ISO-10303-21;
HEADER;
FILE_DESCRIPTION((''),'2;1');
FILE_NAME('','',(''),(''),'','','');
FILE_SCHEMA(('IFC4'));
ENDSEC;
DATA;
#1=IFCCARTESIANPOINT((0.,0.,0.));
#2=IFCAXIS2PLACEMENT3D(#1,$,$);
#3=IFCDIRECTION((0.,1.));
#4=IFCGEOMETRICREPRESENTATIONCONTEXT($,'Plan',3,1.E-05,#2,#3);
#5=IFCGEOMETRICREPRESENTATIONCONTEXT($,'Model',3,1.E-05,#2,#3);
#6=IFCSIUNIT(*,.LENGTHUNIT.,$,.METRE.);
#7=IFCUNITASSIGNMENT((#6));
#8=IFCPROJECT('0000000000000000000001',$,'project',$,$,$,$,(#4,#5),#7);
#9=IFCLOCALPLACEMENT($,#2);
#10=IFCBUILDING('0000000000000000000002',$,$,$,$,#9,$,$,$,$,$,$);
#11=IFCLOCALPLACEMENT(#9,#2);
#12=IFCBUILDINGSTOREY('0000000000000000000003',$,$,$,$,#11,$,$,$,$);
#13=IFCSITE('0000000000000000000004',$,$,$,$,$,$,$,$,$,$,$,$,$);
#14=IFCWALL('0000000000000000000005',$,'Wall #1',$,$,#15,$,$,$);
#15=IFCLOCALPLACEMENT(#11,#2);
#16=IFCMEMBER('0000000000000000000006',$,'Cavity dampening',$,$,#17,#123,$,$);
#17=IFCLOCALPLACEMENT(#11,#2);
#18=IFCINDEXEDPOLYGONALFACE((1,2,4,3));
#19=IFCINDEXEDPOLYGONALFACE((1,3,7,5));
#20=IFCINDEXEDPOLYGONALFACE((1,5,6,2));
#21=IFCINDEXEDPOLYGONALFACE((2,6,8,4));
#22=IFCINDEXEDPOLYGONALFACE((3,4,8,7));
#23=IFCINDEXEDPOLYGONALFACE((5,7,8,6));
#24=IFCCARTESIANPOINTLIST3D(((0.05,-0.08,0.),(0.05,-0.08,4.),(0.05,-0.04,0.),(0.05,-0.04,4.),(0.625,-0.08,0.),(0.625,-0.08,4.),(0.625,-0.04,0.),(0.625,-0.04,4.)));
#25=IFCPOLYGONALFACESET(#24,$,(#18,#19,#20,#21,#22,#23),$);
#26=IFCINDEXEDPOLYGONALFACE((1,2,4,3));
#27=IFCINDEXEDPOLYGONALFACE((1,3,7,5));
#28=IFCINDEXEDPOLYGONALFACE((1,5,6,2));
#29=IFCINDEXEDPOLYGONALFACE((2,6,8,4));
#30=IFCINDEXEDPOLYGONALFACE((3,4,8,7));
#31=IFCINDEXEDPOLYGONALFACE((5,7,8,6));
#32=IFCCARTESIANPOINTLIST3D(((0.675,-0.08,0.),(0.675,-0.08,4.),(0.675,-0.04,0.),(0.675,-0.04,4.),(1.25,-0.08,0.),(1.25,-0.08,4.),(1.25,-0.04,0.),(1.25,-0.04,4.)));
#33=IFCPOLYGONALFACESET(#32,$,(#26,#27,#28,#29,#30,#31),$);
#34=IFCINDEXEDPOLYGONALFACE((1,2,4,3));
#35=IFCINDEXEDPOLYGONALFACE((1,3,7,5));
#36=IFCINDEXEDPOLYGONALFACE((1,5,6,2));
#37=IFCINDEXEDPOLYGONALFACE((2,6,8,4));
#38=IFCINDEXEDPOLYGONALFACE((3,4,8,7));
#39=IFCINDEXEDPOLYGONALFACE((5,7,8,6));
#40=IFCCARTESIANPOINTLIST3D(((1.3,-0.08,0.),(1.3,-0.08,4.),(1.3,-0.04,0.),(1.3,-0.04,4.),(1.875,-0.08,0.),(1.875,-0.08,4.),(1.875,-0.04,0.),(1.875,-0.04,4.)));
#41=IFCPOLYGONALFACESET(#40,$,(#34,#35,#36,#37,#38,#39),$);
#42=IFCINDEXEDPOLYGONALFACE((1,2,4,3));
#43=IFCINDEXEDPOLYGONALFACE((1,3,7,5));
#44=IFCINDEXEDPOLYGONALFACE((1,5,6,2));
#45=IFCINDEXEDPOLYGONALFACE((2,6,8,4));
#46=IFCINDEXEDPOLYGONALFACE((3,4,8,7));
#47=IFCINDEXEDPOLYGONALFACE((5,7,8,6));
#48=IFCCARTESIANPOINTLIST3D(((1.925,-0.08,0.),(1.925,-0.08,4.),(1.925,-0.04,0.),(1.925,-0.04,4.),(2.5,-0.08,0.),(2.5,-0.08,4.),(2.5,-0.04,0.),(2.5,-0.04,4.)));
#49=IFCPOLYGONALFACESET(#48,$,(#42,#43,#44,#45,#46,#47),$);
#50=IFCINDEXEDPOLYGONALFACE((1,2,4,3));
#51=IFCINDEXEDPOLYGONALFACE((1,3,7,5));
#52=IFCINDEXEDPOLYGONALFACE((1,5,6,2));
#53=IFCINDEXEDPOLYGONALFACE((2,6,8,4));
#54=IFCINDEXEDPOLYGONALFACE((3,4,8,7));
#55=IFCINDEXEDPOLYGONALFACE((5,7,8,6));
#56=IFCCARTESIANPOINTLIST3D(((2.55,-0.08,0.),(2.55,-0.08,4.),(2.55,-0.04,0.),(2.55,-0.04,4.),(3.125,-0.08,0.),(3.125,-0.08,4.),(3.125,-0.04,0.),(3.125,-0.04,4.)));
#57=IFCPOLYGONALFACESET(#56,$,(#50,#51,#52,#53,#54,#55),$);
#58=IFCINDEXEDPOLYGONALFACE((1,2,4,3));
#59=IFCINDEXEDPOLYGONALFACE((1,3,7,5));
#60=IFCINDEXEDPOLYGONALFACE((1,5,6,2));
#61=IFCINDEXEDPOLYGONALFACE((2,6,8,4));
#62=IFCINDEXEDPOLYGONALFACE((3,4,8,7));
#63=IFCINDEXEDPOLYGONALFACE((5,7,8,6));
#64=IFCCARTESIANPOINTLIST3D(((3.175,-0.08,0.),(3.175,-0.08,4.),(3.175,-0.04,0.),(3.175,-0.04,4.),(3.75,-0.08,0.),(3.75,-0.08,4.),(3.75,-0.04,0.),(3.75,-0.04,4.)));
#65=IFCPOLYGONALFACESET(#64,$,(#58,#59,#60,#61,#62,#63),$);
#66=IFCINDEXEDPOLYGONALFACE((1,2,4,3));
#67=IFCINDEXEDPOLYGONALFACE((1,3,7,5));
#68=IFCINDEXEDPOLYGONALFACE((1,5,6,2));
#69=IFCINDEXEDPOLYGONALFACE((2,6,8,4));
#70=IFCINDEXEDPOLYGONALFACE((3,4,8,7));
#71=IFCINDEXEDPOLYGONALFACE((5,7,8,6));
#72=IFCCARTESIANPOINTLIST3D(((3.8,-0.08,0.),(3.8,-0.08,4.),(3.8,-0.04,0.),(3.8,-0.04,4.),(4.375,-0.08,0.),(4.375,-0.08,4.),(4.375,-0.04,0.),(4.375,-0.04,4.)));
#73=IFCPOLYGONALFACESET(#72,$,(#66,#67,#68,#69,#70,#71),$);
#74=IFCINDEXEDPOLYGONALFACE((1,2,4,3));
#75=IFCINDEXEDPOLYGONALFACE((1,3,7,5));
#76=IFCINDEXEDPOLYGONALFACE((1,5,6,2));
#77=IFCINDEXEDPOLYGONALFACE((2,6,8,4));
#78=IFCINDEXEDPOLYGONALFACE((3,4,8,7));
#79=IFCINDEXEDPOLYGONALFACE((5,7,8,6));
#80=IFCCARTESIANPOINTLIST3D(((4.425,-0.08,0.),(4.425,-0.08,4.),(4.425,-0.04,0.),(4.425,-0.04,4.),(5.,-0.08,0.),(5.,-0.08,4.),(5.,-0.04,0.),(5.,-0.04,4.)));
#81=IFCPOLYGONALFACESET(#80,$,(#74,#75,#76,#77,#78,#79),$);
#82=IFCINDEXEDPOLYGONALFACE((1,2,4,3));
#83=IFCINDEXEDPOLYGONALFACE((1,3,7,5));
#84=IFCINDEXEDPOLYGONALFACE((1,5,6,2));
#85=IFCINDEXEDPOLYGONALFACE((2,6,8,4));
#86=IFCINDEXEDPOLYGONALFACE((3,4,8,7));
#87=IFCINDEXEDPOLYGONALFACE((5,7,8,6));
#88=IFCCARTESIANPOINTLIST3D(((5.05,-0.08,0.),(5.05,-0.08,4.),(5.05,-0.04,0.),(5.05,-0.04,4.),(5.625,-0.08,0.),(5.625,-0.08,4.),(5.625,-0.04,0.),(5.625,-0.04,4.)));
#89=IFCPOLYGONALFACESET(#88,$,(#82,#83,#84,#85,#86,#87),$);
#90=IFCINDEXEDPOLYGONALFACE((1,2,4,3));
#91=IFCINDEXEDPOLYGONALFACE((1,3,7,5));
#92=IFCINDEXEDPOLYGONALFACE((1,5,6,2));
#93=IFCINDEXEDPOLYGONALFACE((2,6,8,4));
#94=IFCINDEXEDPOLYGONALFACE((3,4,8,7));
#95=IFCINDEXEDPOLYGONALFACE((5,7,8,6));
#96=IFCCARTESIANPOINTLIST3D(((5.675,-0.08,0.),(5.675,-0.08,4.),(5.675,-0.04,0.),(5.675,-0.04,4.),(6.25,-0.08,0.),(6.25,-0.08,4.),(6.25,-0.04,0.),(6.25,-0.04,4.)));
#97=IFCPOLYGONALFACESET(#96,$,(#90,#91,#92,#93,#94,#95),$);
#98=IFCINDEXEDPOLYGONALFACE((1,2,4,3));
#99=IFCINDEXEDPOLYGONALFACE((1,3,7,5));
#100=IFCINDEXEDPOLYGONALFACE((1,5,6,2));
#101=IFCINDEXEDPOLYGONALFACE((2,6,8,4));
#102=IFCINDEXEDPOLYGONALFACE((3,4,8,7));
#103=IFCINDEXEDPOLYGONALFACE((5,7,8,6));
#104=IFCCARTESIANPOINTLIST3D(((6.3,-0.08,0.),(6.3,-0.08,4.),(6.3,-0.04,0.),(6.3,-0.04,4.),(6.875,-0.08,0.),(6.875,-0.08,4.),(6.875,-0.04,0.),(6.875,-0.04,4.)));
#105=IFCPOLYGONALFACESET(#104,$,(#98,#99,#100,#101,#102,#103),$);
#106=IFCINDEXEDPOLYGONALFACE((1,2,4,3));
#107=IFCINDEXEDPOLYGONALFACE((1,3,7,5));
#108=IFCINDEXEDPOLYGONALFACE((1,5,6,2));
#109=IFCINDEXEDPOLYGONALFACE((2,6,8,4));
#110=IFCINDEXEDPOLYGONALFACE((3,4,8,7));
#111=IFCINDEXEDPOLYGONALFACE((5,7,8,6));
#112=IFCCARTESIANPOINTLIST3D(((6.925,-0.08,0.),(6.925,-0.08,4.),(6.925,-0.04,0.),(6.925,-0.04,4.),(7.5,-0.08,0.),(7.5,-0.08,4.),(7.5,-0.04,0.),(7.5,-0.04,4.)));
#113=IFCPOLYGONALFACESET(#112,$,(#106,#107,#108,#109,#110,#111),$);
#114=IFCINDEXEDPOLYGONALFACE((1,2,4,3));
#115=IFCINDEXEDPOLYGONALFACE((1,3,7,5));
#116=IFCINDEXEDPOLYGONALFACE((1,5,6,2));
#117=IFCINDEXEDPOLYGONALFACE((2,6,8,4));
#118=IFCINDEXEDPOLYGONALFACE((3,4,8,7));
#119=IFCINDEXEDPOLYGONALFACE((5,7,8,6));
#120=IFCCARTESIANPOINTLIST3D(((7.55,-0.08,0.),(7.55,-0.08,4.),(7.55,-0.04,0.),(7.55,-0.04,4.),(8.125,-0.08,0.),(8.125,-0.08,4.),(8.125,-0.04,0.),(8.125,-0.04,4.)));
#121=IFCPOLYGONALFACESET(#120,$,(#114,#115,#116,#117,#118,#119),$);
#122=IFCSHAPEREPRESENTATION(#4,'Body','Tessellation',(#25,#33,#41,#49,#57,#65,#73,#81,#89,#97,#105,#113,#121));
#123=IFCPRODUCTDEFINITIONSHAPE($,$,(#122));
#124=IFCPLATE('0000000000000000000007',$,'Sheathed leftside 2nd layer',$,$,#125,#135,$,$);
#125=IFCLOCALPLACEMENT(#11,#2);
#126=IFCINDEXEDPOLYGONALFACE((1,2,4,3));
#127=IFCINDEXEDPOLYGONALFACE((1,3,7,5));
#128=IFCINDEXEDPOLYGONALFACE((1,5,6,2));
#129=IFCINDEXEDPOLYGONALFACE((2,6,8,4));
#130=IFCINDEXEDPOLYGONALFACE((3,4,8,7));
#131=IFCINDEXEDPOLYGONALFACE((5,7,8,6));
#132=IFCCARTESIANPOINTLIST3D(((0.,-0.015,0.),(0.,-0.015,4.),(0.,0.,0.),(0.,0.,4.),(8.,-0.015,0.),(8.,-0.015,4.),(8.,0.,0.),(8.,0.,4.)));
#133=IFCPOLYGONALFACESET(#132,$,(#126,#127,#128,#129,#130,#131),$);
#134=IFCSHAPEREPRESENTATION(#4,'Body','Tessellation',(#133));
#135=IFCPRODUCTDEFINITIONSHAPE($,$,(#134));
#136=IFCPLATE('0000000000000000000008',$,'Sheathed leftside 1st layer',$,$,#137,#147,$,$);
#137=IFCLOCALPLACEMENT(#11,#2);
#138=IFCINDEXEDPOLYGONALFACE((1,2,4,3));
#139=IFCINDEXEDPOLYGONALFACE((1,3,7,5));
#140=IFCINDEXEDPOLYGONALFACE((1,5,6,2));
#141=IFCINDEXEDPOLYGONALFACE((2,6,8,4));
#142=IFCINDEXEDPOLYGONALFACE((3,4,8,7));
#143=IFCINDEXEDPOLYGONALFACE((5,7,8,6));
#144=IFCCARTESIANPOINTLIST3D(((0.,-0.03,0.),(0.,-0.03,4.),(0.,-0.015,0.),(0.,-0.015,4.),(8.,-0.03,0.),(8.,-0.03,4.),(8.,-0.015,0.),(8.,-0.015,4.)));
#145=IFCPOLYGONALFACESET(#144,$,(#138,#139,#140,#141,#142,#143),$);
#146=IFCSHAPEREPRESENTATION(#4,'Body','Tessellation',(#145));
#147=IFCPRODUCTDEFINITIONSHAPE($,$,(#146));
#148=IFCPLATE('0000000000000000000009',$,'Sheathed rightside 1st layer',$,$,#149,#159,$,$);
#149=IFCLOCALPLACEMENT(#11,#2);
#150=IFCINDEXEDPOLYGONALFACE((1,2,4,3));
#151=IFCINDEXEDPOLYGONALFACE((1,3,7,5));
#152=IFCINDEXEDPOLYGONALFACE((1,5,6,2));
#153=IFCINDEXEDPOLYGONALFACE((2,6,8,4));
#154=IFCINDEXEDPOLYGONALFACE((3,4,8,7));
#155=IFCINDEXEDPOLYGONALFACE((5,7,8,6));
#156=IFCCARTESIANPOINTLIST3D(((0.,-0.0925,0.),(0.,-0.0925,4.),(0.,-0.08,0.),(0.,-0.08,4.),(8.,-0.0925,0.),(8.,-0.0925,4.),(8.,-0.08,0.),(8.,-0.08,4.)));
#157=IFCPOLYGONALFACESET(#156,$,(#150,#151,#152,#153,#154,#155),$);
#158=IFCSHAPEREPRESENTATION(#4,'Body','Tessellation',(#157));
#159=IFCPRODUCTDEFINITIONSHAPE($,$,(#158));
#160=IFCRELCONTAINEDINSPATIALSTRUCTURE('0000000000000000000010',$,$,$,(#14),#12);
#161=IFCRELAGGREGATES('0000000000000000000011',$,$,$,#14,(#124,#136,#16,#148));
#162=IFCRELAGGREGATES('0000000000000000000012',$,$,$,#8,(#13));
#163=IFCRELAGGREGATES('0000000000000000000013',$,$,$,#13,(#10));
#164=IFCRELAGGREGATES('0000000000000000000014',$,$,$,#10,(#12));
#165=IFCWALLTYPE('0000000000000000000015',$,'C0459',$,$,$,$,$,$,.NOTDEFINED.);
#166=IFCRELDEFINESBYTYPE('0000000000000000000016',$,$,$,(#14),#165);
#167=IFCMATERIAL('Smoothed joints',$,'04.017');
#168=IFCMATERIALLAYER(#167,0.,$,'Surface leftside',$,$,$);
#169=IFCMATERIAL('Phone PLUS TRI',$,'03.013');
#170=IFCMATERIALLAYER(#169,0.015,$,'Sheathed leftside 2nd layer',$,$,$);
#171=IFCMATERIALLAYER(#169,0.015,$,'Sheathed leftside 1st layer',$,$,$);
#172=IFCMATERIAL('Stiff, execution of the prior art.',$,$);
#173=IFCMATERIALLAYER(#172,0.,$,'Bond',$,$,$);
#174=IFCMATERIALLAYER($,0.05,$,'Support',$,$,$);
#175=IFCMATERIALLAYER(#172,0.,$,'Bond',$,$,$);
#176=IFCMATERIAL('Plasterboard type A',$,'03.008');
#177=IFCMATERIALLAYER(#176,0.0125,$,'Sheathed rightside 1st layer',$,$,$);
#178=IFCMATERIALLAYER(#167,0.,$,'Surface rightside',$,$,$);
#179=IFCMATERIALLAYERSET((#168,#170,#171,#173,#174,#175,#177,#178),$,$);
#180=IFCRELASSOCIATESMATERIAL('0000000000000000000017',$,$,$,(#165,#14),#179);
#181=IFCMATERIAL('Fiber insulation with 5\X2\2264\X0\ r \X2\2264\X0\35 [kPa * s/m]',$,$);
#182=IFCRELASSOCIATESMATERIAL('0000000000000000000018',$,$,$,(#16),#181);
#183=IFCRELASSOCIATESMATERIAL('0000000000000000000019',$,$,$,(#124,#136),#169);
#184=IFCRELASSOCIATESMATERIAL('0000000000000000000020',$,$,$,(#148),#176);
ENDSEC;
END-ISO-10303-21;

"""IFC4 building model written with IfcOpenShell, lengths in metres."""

from ifc_helpers import new_model, si_unit, direction, frame, frame_2d, origin, origin_with_axes, place, context, project, spatial, rectangle, extrude, material, layer, layer_set, type_object, element, aggregate, save


model = new_model("IFC4")

# Units and contexts
plan_context = context("Plan", 3, precision=1e-05, world=origin(), true_north=direction((0.0, 1.0)))
model_context = context("Model", 3, precision=1e-05, world=origin(), true_north=direction((0.0, 1.0)))
ifc_project = project(units=[si_unit("LENGTHUNIT", "METRE")], contexts=[plan_context, model_context])

# Site, building, storey
site = spatial("IfcSite", under=ifc_project)
building_placement = place(None, origin())
building = spatial("IfcBuilding", under=site, at=building_placement)
storey_placement = place(building_placement, origin())
storey = spatial("IfcBuildingStorey", under=building, at=storey_placement)

# Wall, member, plates
ifc_material_1 = material(Name="Smoothed joints", Category="04.017")
ifc_layer_1 = layer(ifc_material_1, 0.0, Name="Surface leftside")
ifc_material_2 = material(Name="Phone PLUS TRI", Category="03.013")
ifc_layer_2 = layer(ifc_material_2, 0.015, Name="Sheathed leftside 2nd layer")
ifc_layer_3 = layer(ifc_material_2, 0.015, Name="Sheathed leftside 1st layer")
ifc_material_3 = material(Name="Stiff, execution of the prior art.")
ifc_layer_4 = layer(ifc_material_3, 0.0, Name="Bond")
ifc_layer_5 = layer(None, 0.05, Name="Support")
ifc_layer_6 = layer(ifc_material_3, 0.0, Name="Bond")
ifc_material_4 = material(Name="Plasterboard type A", Category="03.008")
ifc_layer_7 = layer(ifc_material_4, 0.0125, Name="Sheathed rightside 1st layer")
ifc_layer_8 = layer(ifc_material_1, 0.0, Name="Surface rightside")
ifc_layer_set = layer_set([ifc_layer_1, ifc_layer_2, ifc_layer_3, ifc_layer_4, ifc_layer_5, ifc_layer_6, ifc_layer_7, ifc_layer_8])
wall_type = type_object("IfcWallType", Name="C0459", PredefinedType="NOTDEFINED", material=ifc_layer_set)
wall_placement = place(None, frame((0.0, 0.0, 0.0), z_axis=(0.0, -1.0, 0.0), x_axis=(1.0, 0.0, 0.0)))
wall = element("IfcWall", 1, at=wall_placement, inside=storey, type_object=wall_type, material=ifc_layer_set, Name="Wall #1")
ifc_material_5 = material(Name="Fiber insulation with 5≤ r ≤35 [kPa * s/m]")
member_1_placement = place(wall_placement, origin())
member_1 = element("IfcMember", 2, at=member_1_placement, material=ifc_material_5, Name="Cavity dampening", context=plan_context, shape_type="SweptSolid", body=[
    extrude(rectangle(XDim=0.575, YDim=0.04, at=frame_2d((0.2875, 0.02), x_axis=(1.0, 0.0))), frame((0.05, 4.0, 0.04), z_axis=(0.0, -1.0, 0.0), x_axis=(1.0, 0.0, 0.0)), (0.0, 0.0, 1.0), 4.0),
    extrude(rectangle(XDim=0.575, YDim=0.04, at=frame_2d((0.2875, 0.02), x_axis=(1.0, 0.0))), frame((0.675, 4.0, 0.04), z_axis=(0.0, -1.0, 0.0), x_axis=(1.0, 0.0, 0.0)), (0.0, 0.0, 1.0), 4.0),
    extrude(rectangle(XDim=0.575, YDim=0.04, at=frame_2d((0.2875, 0.02), x_axis=(1.0, 0.0))), frame((1.3, 4.0, 0.04), z_axis=(0.0, -1.0, 0.0), x_axis=(1.0, 0.0, 0.0)), (0.0, 0.0, 1.0), 4.0),
    extrude(rectangle(XDim=0.575, YDim=0.04, at=frame_2d((0.2875, 0.02), x_axis=(1.0, 0.0))), frame((1.925, 4.0, 0.04), z_axis=(0.0, -1.0, 0.0), x_axis=(1.0, 0.0, 0.0)), (0.0, 0.0, 1.0), 4.0),
    extrude(rectangle(XDim=0.575, YDim=0.04, at=frame_2d((0.2875, 0.02), x_axis=(1.0, 0.0))), frame((2.55, 4.0, 0.04), z_axis=(0.0, -1.0, 0.0), x_axis=(1.0, 0.0, 0.0)), (0.0, 0.0, 1.0), 4.0),
    extrude(rectangle(XDim=0.575, YDim=0.04, at=frame_2d((0.2875, 0.02), x_axis=(1.0, 0.0))), frame((3.175, 4.0, 0.04), z_axis=(0.0, -1.0, 0.0), x_axis=(1.0, 0.0, 0.0)), (0.0, 0.0, 1.0), 4.0),
    extrude(rectangle(XDim=0.575, YDim=0.04, at=frame_2d((0.2875, 0.02), x_axis=(1.0, 0.0))), frame((3.8, 4.0, 0.04), z_axis=(0.0, -1.0, 0.0), x_axis=(1.0, 0.0, 0.0)), (0.0, 0.0, 1.0), 4.0),
    extrude(rectangle(XDim=0.575, YDim=0.04, at=frame_2d((0.2875, 0.02), x_axis=(1.0, 0.0))), frame((4.425, 4.0, 0.04), z_axis=(0.0, -1.0, 0.0), x_axis=(1.0, 0.0, 0.0)), (0.0, 0.0, 1.0), 4.0),
    extrude(rectangle(XDim=0.575, YDim=0.04, at=frame_2d((0.2875, 0.02), x_axis=(1.0, 0.0))), frame((5.05, 4.0, 0.04), z_axis=(0.0, -1.0, 0.0), x_axis=(1.0, 0.0, 0.0)), (0.0, 0.0, 1.0), 4.0),
    extrude(rectangle(XDim=0.575, YDim=0.04, at=frame_2d((0.2875, 0.02), x_axis=(1.0, 0.0))), frame((5.675, 4.0, 0.04), z_axis=(0.0, -1.0, 0.0), x_axis=(1.0, 0.0, 0.0)), (0.0, 0.0, 1.0), 4.0),
    extrude(rectangle(XDim=0.575, YDim=0.04, at=frame_2d((0.2875, 0.02), x_axis=(1.0, 0.0))), frame((6.3, 4.0, 0.04), z_axis=(0.0, -1.0, 0.0), x_axis=(1.0, 0.0, 0.0)), (0.0, 0.0, 1.0), 4.0),
    extrude(rectangle(XDim=0.575, YDim=0.04, at=frame_2d((0.2875, 0.02), x_axis=(1.0, 0.0))), frame((6.925, 4.0, 0.04), z_axis=(0.0, -1.0, 0.0), x_axis=(1.0, 0.0, 0.0)), (0.0, 0.0, 1.0), 4.0),
    extrude(rectangle(XDim=0.575, YDim=0.04, at=frame_2d((0.2875, 0.02), x_axis=(1.0, 0.0))), frame((7.55, 4.0, 0.04), z_axis=(0.0, -1.0, 0.0), x_axis=(1.0, 0.0, 0.0)), (0.0, 0.0, 1.0), 4.0),
])
plate_1_placement = place(wall_placement, origin())
plate_1 = element("IfcPlate", 3, at=plate_1_placement, material=ifc_material_2, Name="Sheathed leftside 2nd layer", context=plan_context, shape_type="SweptSolid", body=[
    extrude(rectangle(XDim=8.0, YDim=4.0, at=frame_2d((4.0, 2.0), x_axis=(1.0, 0.0))), origin_with_axes(), (0.0, 0.0, 1.0), 0.015),
])
plate_2_placement = place(wall_placement, origin())
plate_2 = element("IfcPlate", 4, at=plate_2_placement, material=ifc_material_2, Name="Sheathed leftside 1st layer", context=plan_context, shape_type="SweptSolid", body=[
    extrude(rectangle(XDim=8.0, YDim=4.0, at=frame_2d((4.0, 2.0), x_axis=(1.0, 0.0))), frame((0.0, 0.0, 0.015), z_axis=(0.0, 0.0, 1.0), x_axis=(1.0, 0.0, 0.0)), (0.0, 0.0, 1.0), 0.015),
])
plate_3_placement = place(wall_placement, origin())
plate_3 = element("IfcPlate", 5, at=plate_3_placement, material=ifc_material_4, Name="Sheathed rightside 1st layer", context=plan_context, shape_type="SweptSolid", body=[
    extrude(rectangle(XDim=8.0, YDim=4.0, at=frame_2d((4.0, 2.0), x_axis=(1.0, 0.0))), frame((0.0, 0.0, 0.08), z_axis=(0.0, 0.0, 1.0), x_axis=(1.0, 0.0, 0.0)), (0.0, 0.0, 1.0), 0.0125),
])
aggregate(wall, [plate_1, plate_2, member_1, plate_3])

save(model, "model.ifc")
